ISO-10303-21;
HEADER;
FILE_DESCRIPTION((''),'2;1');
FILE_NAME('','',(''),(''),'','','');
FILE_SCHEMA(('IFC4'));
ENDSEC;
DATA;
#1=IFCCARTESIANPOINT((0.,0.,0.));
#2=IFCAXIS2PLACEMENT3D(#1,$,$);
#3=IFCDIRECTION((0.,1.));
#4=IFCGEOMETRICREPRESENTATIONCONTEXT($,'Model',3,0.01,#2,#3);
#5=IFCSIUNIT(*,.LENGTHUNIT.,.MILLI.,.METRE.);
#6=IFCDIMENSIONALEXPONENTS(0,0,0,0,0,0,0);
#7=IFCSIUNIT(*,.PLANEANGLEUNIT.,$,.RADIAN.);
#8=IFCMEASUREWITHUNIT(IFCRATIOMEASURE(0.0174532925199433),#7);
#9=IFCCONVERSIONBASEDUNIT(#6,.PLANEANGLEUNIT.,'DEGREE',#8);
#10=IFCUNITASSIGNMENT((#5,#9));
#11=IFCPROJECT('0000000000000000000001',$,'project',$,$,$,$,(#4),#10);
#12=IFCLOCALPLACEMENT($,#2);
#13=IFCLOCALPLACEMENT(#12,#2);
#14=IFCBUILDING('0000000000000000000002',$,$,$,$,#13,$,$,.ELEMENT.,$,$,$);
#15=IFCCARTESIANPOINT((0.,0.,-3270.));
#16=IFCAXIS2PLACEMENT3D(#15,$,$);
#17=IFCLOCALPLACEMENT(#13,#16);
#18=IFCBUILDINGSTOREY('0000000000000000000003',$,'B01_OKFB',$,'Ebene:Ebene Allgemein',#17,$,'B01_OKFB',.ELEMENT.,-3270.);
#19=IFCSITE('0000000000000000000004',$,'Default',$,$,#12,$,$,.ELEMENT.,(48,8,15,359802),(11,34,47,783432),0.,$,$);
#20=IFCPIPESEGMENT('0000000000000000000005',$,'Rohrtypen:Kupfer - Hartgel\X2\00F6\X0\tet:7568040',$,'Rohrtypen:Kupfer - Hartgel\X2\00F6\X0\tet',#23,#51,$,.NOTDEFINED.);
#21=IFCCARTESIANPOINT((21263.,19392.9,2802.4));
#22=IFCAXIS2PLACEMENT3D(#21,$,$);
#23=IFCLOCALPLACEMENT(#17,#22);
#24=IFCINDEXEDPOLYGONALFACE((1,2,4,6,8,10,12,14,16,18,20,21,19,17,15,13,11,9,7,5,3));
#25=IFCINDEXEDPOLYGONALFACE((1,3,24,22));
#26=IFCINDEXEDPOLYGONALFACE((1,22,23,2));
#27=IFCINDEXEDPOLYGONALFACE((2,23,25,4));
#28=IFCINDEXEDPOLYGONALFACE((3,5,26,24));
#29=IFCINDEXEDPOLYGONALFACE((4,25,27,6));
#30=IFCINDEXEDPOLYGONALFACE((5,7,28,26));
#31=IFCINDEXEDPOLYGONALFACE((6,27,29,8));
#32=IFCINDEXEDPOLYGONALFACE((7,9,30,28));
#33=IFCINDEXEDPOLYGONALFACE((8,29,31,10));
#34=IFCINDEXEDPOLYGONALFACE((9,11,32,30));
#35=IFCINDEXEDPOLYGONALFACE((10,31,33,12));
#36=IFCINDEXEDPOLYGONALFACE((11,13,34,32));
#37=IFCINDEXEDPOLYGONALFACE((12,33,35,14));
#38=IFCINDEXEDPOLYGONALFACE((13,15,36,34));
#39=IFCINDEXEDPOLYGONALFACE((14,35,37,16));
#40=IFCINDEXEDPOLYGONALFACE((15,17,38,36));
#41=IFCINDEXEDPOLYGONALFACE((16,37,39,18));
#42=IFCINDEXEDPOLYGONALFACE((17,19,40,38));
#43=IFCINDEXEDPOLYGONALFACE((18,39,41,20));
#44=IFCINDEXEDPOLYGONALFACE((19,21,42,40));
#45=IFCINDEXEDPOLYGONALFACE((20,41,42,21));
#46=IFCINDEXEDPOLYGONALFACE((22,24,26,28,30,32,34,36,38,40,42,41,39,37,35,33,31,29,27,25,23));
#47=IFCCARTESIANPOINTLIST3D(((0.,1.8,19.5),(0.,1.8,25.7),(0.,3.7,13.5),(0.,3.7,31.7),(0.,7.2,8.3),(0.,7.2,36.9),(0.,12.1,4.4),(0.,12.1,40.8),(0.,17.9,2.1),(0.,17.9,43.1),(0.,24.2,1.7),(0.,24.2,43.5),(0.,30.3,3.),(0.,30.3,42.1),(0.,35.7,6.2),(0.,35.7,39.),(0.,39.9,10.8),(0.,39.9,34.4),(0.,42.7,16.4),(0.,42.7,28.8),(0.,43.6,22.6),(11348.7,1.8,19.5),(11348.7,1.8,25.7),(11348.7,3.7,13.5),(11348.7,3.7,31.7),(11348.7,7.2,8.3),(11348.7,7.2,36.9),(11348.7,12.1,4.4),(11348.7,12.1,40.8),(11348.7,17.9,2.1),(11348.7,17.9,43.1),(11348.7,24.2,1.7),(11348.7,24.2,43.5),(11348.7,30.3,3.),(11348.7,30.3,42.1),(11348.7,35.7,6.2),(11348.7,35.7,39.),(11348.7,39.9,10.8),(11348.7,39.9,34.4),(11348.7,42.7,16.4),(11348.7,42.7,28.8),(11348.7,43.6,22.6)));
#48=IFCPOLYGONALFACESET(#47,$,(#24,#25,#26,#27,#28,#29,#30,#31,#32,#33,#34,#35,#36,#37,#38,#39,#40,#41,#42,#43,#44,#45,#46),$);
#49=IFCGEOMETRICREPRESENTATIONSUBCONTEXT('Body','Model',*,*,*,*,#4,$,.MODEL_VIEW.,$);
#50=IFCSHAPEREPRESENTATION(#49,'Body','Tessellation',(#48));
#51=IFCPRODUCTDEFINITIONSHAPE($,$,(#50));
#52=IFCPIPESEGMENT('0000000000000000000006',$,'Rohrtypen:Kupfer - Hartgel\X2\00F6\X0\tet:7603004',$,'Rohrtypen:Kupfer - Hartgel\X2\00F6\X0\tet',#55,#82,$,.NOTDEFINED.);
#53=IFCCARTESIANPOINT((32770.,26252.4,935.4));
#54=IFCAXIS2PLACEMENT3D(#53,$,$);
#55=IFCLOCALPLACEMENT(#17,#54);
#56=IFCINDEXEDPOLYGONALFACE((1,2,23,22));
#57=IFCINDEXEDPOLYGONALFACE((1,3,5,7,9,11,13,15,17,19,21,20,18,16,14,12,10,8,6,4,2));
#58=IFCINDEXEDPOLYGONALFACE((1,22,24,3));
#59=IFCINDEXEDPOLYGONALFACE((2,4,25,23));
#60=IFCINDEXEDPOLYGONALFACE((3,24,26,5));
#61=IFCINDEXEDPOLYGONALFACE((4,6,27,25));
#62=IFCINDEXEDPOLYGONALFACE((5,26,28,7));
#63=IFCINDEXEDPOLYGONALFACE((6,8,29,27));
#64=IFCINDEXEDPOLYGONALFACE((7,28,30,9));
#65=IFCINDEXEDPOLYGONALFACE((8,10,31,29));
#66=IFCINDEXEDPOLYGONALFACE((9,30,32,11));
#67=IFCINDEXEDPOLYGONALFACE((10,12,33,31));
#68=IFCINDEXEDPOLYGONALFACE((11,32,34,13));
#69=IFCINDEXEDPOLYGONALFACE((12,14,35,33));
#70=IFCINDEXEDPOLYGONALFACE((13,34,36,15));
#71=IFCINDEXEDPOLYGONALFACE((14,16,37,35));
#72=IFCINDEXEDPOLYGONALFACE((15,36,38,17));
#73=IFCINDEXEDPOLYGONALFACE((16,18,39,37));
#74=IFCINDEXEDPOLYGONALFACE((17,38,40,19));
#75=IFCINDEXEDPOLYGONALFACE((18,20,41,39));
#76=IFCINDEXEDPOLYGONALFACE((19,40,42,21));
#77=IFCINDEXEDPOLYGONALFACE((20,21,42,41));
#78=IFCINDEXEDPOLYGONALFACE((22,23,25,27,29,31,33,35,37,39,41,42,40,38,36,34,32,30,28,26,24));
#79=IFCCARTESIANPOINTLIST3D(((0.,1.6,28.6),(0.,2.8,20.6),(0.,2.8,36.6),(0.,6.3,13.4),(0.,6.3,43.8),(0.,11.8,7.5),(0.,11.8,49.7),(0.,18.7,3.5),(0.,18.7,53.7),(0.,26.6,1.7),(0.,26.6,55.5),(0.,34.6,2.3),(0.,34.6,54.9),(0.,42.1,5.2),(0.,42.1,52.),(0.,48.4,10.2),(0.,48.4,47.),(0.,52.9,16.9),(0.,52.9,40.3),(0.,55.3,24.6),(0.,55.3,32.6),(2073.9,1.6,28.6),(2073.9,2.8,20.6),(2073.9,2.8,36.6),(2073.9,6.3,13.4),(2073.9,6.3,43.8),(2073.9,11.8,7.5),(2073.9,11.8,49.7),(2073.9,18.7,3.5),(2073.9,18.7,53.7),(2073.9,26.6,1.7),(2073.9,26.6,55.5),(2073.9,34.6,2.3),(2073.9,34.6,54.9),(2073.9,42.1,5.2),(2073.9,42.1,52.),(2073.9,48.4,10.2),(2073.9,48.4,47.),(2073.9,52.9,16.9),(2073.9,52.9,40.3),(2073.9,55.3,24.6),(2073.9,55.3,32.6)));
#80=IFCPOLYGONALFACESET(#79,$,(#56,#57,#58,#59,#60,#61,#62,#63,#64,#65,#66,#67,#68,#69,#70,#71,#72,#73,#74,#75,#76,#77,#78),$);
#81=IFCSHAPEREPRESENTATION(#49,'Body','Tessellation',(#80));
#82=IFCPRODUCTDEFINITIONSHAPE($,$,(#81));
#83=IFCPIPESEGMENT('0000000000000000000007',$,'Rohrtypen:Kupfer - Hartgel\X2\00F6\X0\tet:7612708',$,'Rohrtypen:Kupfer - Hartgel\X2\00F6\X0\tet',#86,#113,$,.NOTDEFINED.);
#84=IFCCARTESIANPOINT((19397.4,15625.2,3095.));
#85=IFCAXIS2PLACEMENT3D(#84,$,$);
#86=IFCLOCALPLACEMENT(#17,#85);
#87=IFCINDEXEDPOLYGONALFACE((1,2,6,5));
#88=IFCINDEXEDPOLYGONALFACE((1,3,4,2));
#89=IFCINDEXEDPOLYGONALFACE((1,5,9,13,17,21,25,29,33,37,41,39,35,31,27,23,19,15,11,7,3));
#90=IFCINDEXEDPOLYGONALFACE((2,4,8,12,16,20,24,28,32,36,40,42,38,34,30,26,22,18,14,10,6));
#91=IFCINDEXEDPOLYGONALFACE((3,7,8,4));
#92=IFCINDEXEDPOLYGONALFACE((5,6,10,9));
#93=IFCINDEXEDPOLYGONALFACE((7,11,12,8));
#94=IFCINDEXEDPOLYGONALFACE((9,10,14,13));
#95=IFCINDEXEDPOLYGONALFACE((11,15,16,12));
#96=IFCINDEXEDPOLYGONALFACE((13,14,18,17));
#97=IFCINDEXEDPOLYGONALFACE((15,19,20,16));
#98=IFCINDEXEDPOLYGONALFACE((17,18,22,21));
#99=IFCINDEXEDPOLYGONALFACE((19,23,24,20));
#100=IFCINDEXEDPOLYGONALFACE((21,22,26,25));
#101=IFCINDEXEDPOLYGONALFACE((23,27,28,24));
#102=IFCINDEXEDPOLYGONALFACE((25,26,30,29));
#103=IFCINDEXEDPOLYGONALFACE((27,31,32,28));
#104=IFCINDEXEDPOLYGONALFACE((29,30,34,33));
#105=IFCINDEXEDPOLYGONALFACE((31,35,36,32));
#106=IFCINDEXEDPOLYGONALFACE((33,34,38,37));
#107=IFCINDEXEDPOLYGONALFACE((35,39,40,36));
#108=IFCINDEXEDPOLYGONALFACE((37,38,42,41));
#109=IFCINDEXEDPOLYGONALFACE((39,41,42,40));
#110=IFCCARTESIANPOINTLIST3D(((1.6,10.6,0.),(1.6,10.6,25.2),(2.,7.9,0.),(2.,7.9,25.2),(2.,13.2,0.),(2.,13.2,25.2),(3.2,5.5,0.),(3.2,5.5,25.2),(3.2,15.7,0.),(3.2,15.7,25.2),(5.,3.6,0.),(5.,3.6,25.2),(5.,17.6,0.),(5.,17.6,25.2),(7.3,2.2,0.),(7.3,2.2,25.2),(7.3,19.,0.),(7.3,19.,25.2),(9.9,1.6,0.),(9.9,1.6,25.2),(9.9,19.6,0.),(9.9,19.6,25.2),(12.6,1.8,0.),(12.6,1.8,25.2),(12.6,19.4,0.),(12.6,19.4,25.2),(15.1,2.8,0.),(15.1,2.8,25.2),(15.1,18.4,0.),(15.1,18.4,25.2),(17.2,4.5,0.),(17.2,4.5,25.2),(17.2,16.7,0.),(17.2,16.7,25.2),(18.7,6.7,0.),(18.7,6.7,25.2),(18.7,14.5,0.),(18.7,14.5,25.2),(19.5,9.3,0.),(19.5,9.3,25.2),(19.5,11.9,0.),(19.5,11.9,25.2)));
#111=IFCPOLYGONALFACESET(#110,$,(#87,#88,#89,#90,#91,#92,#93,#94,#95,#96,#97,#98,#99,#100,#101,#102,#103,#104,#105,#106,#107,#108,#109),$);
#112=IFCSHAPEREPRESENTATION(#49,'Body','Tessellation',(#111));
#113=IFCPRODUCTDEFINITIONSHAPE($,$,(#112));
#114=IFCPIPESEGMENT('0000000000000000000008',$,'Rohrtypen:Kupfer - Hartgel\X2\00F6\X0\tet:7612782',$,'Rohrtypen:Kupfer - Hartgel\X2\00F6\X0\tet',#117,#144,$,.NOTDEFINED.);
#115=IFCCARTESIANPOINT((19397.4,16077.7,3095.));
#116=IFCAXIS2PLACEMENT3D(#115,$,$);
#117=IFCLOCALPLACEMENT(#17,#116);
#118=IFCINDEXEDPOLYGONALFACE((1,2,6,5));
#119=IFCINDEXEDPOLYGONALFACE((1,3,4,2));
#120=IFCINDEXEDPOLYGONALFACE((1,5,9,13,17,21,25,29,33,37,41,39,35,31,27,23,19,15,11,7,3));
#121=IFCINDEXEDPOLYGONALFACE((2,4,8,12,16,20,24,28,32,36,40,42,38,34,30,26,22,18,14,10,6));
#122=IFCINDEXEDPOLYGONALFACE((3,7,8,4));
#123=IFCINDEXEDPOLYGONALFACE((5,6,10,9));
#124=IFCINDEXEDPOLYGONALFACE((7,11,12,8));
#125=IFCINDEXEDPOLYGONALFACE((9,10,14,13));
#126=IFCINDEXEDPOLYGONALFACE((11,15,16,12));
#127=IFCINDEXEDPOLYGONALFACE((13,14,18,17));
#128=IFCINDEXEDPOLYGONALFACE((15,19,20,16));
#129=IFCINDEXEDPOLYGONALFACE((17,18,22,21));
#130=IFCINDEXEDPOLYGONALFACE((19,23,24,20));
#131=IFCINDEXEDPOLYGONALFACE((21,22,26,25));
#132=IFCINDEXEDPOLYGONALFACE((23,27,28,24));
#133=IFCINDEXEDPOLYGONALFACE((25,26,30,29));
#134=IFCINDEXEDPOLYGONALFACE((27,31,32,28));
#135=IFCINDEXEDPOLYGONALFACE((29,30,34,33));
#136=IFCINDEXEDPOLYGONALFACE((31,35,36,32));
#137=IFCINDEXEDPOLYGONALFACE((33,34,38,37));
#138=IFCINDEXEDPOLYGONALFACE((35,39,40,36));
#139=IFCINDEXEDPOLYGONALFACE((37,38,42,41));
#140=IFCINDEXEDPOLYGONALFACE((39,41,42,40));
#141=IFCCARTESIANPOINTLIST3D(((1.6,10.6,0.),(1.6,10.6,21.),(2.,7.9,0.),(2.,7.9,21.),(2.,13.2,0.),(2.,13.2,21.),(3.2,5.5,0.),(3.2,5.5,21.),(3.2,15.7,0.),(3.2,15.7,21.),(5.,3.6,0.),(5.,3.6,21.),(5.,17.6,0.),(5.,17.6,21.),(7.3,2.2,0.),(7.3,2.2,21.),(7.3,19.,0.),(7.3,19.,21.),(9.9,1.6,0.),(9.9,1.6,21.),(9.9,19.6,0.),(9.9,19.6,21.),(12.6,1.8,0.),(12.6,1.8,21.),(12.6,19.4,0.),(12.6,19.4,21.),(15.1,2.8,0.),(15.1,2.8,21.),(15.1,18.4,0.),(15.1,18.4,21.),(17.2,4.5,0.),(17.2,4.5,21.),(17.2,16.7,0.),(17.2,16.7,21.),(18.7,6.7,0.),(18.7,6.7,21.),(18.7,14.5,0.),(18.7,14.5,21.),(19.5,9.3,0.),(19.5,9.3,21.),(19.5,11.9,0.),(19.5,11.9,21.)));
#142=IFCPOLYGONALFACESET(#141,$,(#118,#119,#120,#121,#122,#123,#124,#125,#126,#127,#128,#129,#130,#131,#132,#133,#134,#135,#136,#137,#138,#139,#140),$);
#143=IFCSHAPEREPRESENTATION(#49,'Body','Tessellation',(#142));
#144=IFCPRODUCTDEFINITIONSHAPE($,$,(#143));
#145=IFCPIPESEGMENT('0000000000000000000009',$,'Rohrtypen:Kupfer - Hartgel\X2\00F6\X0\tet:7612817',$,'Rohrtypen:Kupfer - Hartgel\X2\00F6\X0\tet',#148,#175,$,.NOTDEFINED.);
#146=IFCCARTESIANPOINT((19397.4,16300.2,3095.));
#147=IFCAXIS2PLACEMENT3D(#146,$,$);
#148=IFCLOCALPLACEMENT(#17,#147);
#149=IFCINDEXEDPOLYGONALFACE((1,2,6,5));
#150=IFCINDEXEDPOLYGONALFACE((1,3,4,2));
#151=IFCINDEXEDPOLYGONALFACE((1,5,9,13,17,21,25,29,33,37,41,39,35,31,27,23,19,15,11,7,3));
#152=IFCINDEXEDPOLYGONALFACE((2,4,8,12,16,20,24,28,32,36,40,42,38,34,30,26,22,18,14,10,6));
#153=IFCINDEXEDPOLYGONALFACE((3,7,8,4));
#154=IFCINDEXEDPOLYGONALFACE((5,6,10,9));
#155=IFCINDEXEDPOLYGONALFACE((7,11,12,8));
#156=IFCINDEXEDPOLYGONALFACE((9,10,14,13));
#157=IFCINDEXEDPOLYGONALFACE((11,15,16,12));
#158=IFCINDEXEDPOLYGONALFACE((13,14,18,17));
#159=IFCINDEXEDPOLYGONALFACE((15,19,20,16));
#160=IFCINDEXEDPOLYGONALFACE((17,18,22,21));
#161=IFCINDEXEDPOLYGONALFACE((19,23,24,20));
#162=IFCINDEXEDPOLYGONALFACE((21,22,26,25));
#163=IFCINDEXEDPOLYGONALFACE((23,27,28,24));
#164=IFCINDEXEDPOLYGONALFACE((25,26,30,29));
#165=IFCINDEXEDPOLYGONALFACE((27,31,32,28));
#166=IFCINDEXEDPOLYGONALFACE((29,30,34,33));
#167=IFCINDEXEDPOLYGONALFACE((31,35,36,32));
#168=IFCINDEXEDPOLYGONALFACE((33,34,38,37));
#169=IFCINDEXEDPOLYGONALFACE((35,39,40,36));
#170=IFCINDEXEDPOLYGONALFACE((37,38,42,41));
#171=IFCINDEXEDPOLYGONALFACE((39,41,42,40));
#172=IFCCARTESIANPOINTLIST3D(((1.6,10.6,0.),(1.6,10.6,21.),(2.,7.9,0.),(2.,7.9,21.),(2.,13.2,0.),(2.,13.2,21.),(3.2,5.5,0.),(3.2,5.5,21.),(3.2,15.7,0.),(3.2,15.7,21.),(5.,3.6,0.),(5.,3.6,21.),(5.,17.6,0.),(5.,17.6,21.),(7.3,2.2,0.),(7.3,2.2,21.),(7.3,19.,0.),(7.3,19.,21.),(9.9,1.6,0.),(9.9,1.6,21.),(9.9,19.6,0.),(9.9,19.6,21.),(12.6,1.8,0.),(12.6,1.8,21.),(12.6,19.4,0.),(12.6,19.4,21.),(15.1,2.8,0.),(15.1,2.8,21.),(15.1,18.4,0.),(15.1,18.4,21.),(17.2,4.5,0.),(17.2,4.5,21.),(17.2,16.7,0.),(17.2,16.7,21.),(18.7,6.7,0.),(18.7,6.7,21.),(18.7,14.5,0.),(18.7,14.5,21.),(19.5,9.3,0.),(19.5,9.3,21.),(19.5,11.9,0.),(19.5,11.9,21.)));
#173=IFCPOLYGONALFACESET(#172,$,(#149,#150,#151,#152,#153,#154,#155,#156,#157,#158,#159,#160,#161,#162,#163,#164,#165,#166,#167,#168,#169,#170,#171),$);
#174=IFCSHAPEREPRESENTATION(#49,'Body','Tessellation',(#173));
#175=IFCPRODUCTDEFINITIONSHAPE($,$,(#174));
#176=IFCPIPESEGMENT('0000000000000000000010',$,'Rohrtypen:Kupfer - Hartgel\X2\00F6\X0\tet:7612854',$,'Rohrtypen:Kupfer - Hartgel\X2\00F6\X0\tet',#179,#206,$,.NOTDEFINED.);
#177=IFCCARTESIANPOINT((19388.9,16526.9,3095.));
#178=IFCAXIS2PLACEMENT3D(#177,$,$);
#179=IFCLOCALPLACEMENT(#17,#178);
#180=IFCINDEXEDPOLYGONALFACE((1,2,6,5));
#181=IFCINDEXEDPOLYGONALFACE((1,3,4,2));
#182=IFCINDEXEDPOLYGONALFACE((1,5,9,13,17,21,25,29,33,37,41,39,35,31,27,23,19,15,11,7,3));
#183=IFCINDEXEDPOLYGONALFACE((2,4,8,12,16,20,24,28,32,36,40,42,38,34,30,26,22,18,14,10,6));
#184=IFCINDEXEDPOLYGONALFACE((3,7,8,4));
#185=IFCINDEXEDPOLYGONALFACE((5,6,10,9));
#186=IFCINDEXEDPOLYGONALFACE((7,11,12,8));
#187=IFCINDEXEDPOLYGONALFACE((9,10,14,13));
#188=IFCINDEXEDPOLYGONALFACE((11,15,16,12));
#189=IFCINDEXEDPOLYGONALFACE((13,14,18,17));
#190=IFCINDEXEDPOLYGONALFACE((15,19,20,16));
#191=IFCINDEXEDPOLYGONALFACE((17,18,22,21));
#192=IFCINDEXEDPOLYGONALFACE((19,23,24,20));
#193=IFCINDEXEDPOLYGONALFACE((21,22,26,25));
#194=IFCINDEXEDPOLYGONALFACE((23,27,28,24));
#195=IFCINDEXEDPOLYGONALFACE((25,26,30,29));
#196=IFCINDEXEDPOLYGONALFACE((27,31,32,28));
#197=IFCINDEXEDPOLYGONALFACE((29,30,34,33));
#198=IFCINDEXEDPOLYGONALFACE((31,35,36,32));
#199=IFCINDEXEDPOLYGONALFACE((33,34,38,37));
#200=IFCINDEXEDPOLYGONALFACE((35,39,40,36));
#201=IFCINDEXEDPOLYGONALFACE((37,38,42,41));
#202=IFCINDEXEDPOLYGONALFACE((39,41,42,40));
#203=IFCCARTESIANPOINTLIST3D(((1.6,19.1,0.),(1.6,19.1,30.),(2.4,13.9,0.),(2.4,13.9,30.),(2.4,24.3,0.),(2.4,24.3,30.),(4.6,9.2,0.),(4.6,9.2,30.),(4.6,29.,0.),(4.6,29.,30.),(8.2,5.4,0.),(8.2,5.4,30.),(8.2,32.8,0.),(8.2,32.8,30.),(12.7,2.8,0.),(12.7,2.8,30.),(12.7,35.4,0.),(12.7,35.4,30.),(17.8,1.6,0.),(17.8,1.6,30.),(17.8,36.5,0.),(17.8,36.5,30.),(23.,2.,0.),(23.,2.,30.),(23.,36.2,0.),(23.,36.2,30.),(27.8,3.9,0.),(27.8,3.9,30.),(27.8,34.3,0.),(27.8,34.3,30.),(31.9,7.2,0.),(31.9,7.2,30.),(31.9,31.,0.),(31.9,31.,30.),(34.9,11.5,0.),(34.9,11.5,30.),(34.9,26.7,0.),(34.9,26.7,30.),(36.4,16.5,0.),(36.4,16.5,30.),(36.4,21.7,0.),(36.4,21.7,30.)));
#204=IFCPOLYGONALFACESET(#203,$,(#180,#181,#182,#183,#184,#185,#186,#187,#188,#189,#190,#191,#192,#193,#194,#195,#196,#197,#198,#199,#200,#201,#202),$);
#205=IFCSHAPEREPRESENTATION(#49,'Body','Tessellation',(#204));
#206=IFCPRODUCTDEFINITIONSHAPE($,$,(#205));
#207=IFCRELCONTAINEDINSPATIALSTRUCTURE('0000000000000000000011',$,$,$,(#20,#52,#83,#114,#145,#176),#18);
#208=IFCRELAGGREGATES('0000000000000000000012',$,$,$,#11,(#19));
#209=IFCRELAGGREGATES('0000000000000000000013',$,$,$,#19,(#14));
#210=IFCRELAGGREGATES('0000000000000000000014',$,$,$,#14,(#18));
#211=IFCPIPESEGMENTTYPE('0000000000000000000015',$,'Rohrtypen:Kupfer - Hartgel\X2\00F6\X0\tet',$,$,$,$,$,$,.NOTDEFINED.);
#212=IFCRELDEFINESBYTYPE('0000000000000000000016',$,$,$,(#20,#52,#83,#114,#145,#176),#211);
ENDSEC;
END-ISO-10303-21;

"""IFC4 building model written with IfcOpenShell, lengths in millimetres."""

from ifc_helpers import new_model, entity, si_unit, converted_unit, direction, frame, origin, origin_2d_with_axis, place, context, subcontext, project, spatial, circle, extrude, type_object, element, save


model = new_model("IFC4")

# Units and contexts
model_context = context("Model", 3, precision=0.01, world=origin(), true_north=direction((0.0, 1.0)))
body_context = subcontext(model_context, "Body", "Model", "MODEL_VIEW")
ifc_project = project(units=[si_unit("LENGTHUNIT", "METRE", prefix="MILLI"), converted_unit("PLANEANGLEUNIT", "DEGREE", entity("IfcRatioMeasure", 0.0174532925199433), si_unit("PLANEANGLEUNIT", "RADIAN"), dimensions=[0, 0, 0, 0, 0, 0, 0])], contexts=[model_context])

# Site, building, storey
site_placement = place(None, origin())
site = spatial("IfcSite", under=ifc_project, at=site_placement, Name="Default", CompositionType="ELEMENT", RefLatitude=(48, 8, 15, 359802), RefLongitude=(11, 34, 47, 783432), RefElevation=0.0)
building_placement = place(site_placement, origin())
building = spatial("IfcBuilding", under=site, at=building_placement, CompositionType="ELEMENT")
storey_placement = place(building_placement, frame((0.0, 0.0, -3270.0)))
storey = spatial("IfcBuildingStorey", under=building, at=storey_placement, Name="B01_OKFB", ObjectType="Ebene:Ebene Allgemein", LongName="B01_OKFB", CompositionType="ELEMENT", Elevation=-3270.0)

# Pipe segments
pipe_segment_type = type_object("IfcPipeSegmentType", Name="Rohrtypen:Kupfer - Hartgelötet", PredefinedType="NOTDEFINED")
pipe_segment_1_placement = place(storey_placement, frame((21263.0, 19392.9, 2802.4)))
element("IfcPipeSegment", 1, at=pipe_segment_1_placement, inside=storey, type_object=pipe_segment_type, Name="Rohrtypen:Kupfer - Hartgelötet:7568040", ObjectType="Rohrtypen:Kupfer - Hartgelötet", PredefinedType="NOTDEFINED", context=body_context, shape_type="SweptSolid", body=[
    extrude(circle(Radius=21.0, at=origin_2d_with_axis()), frame((0.0, 22.6, 22.6), z_axis=(1.0, 0.0, 0.0), x_axis=(0.0, 1.0, 0.0)), (0.0, 0.0, 1.0), 11348.7),
])
pipe_segment_2_placement = place(storey_placement, frame((32770.0, 26252.4, 935.4)))
element("IfcPipeSegment", 2, at=pipe_segment_2_placement, inside=storey, type_object=pipe_segment_type, Name="Rohrtypen:Kupfer - Hartgelötet:7603004", ObjectType="Rohrtypen:Kupfer - Hartgelötet", PredefinedType="NOTDEFINED", context=body_context, shape_type="SweptSolid", body=[
    extrude(circle(Radius=27.0, at=origin_2d_with_axis()), frame((0.0, 28.6, 28.6), z_axis=(1.0, 0.0, 0.0), x_axis=(0.0, -1.0, 0.0)), (0.0, 0.0, 1.0), 2073.9),
])
pipe_segment_3_placement = place(storey_placement, frame((19397.4, 15625.2, 3095.0)))
element("IfcPipeSegment", 3, at=pipe_segment_3_placement, inside=storey, type_object=pipe_segment_type, Name="Rohrtypen:Kupfer - Hartgelötet:7612708", ObjectType="Rohrtypen:Kupfer - Hartgelötet", PredefinedType="NOTDEFINED", context=body_context, shape_type="SweptSolid", body=[
    extrude(circle(Radius=9.0, at=origin_2d_with_axis()), frame((10.6, 10.6, 0.0), z_axis=(0.0, 0.0, 1.0), x_axis=(-1.0, 0.0, 0.0)), (0.0, 0.0, 1.0), 25.2),
])
pipe_segment_4_placement = place(storey_placement, frame((19397.4, 16077.7, 3095.0)))
element("IfcPipeSegment", 4, at=pipe_segment_4_placement, inside=storey, type_object=pipe_segment_type, Name="Rohrtypen:Kupfer - Hartgelötet:7612782", ObjectType="Rohrtypen:Kupfer - Hartgelötet", PredefinedType="NOTDEFINED", context=body_context, shape_type="SweptSolid", body=[
    extrude(circle(Radius=9.0, at=origin_2d_with_axis()), frame((10.6, 10.6, 0.0), z_axis=(0.0, 0.0, 1.0), x_axis=(-1.0, 0.0, 0.0)), (0.0, 0.0, 1.0), 21.0),
])
pipe_segment_5_placement = place(storey_placement, frame((19397.4, 16300.2, 3095.0)))
element("IfcPipeSegment", 5, at=pipe_segment_5_placement, inside=storey, type_object=pipe_segment_type, Name="Rohrtypen:Kupfer - Hartgelötet:7612817", ObjectType="Rohrtypen:Kupfer - Hartgelötet", PredefinedType="NOTDEFINED", context=body_context, shape_type="SweptSolid", body=[
    extrude(circle(Radius=9.0, at=origin_2d_with_axis()), frame((10.6, 10.6, 0.0), z_axis=(0.0, 0.0, 1.0), x_axis=(-1.0, 0.0, 0.0)), (0.0, 0.0, 1.0), 21.0),
])
pipe_segment_6_placement = place(storey_placement, frame((19388.9, 16526.9, 3095.0)))
element("IfcPipeSegment", 6, at=pipe_segment_6_placement, inside=storey, type_object=pipe_segment_type, Name="Rohrtypen:Kupfer - Hartgelötet:7612854", ObjectType="Rohrtypen:Kupfer - Hartgelötet", PredefinedType="NOTDEFINED", context=body_context, shape_type="SweptSolid", body=[
    extrude(circle(Radius=17.5, at=origin_2d_with_axis()), frame((19.1, 19.1, 0.0), z_axis=(0.0, 0.0, 1.0), x_axis=(-1.0, 0.0, 0.0)), (0.0, 0.0, 1.0), 30.0),
])

save(model, "model.ifc")
